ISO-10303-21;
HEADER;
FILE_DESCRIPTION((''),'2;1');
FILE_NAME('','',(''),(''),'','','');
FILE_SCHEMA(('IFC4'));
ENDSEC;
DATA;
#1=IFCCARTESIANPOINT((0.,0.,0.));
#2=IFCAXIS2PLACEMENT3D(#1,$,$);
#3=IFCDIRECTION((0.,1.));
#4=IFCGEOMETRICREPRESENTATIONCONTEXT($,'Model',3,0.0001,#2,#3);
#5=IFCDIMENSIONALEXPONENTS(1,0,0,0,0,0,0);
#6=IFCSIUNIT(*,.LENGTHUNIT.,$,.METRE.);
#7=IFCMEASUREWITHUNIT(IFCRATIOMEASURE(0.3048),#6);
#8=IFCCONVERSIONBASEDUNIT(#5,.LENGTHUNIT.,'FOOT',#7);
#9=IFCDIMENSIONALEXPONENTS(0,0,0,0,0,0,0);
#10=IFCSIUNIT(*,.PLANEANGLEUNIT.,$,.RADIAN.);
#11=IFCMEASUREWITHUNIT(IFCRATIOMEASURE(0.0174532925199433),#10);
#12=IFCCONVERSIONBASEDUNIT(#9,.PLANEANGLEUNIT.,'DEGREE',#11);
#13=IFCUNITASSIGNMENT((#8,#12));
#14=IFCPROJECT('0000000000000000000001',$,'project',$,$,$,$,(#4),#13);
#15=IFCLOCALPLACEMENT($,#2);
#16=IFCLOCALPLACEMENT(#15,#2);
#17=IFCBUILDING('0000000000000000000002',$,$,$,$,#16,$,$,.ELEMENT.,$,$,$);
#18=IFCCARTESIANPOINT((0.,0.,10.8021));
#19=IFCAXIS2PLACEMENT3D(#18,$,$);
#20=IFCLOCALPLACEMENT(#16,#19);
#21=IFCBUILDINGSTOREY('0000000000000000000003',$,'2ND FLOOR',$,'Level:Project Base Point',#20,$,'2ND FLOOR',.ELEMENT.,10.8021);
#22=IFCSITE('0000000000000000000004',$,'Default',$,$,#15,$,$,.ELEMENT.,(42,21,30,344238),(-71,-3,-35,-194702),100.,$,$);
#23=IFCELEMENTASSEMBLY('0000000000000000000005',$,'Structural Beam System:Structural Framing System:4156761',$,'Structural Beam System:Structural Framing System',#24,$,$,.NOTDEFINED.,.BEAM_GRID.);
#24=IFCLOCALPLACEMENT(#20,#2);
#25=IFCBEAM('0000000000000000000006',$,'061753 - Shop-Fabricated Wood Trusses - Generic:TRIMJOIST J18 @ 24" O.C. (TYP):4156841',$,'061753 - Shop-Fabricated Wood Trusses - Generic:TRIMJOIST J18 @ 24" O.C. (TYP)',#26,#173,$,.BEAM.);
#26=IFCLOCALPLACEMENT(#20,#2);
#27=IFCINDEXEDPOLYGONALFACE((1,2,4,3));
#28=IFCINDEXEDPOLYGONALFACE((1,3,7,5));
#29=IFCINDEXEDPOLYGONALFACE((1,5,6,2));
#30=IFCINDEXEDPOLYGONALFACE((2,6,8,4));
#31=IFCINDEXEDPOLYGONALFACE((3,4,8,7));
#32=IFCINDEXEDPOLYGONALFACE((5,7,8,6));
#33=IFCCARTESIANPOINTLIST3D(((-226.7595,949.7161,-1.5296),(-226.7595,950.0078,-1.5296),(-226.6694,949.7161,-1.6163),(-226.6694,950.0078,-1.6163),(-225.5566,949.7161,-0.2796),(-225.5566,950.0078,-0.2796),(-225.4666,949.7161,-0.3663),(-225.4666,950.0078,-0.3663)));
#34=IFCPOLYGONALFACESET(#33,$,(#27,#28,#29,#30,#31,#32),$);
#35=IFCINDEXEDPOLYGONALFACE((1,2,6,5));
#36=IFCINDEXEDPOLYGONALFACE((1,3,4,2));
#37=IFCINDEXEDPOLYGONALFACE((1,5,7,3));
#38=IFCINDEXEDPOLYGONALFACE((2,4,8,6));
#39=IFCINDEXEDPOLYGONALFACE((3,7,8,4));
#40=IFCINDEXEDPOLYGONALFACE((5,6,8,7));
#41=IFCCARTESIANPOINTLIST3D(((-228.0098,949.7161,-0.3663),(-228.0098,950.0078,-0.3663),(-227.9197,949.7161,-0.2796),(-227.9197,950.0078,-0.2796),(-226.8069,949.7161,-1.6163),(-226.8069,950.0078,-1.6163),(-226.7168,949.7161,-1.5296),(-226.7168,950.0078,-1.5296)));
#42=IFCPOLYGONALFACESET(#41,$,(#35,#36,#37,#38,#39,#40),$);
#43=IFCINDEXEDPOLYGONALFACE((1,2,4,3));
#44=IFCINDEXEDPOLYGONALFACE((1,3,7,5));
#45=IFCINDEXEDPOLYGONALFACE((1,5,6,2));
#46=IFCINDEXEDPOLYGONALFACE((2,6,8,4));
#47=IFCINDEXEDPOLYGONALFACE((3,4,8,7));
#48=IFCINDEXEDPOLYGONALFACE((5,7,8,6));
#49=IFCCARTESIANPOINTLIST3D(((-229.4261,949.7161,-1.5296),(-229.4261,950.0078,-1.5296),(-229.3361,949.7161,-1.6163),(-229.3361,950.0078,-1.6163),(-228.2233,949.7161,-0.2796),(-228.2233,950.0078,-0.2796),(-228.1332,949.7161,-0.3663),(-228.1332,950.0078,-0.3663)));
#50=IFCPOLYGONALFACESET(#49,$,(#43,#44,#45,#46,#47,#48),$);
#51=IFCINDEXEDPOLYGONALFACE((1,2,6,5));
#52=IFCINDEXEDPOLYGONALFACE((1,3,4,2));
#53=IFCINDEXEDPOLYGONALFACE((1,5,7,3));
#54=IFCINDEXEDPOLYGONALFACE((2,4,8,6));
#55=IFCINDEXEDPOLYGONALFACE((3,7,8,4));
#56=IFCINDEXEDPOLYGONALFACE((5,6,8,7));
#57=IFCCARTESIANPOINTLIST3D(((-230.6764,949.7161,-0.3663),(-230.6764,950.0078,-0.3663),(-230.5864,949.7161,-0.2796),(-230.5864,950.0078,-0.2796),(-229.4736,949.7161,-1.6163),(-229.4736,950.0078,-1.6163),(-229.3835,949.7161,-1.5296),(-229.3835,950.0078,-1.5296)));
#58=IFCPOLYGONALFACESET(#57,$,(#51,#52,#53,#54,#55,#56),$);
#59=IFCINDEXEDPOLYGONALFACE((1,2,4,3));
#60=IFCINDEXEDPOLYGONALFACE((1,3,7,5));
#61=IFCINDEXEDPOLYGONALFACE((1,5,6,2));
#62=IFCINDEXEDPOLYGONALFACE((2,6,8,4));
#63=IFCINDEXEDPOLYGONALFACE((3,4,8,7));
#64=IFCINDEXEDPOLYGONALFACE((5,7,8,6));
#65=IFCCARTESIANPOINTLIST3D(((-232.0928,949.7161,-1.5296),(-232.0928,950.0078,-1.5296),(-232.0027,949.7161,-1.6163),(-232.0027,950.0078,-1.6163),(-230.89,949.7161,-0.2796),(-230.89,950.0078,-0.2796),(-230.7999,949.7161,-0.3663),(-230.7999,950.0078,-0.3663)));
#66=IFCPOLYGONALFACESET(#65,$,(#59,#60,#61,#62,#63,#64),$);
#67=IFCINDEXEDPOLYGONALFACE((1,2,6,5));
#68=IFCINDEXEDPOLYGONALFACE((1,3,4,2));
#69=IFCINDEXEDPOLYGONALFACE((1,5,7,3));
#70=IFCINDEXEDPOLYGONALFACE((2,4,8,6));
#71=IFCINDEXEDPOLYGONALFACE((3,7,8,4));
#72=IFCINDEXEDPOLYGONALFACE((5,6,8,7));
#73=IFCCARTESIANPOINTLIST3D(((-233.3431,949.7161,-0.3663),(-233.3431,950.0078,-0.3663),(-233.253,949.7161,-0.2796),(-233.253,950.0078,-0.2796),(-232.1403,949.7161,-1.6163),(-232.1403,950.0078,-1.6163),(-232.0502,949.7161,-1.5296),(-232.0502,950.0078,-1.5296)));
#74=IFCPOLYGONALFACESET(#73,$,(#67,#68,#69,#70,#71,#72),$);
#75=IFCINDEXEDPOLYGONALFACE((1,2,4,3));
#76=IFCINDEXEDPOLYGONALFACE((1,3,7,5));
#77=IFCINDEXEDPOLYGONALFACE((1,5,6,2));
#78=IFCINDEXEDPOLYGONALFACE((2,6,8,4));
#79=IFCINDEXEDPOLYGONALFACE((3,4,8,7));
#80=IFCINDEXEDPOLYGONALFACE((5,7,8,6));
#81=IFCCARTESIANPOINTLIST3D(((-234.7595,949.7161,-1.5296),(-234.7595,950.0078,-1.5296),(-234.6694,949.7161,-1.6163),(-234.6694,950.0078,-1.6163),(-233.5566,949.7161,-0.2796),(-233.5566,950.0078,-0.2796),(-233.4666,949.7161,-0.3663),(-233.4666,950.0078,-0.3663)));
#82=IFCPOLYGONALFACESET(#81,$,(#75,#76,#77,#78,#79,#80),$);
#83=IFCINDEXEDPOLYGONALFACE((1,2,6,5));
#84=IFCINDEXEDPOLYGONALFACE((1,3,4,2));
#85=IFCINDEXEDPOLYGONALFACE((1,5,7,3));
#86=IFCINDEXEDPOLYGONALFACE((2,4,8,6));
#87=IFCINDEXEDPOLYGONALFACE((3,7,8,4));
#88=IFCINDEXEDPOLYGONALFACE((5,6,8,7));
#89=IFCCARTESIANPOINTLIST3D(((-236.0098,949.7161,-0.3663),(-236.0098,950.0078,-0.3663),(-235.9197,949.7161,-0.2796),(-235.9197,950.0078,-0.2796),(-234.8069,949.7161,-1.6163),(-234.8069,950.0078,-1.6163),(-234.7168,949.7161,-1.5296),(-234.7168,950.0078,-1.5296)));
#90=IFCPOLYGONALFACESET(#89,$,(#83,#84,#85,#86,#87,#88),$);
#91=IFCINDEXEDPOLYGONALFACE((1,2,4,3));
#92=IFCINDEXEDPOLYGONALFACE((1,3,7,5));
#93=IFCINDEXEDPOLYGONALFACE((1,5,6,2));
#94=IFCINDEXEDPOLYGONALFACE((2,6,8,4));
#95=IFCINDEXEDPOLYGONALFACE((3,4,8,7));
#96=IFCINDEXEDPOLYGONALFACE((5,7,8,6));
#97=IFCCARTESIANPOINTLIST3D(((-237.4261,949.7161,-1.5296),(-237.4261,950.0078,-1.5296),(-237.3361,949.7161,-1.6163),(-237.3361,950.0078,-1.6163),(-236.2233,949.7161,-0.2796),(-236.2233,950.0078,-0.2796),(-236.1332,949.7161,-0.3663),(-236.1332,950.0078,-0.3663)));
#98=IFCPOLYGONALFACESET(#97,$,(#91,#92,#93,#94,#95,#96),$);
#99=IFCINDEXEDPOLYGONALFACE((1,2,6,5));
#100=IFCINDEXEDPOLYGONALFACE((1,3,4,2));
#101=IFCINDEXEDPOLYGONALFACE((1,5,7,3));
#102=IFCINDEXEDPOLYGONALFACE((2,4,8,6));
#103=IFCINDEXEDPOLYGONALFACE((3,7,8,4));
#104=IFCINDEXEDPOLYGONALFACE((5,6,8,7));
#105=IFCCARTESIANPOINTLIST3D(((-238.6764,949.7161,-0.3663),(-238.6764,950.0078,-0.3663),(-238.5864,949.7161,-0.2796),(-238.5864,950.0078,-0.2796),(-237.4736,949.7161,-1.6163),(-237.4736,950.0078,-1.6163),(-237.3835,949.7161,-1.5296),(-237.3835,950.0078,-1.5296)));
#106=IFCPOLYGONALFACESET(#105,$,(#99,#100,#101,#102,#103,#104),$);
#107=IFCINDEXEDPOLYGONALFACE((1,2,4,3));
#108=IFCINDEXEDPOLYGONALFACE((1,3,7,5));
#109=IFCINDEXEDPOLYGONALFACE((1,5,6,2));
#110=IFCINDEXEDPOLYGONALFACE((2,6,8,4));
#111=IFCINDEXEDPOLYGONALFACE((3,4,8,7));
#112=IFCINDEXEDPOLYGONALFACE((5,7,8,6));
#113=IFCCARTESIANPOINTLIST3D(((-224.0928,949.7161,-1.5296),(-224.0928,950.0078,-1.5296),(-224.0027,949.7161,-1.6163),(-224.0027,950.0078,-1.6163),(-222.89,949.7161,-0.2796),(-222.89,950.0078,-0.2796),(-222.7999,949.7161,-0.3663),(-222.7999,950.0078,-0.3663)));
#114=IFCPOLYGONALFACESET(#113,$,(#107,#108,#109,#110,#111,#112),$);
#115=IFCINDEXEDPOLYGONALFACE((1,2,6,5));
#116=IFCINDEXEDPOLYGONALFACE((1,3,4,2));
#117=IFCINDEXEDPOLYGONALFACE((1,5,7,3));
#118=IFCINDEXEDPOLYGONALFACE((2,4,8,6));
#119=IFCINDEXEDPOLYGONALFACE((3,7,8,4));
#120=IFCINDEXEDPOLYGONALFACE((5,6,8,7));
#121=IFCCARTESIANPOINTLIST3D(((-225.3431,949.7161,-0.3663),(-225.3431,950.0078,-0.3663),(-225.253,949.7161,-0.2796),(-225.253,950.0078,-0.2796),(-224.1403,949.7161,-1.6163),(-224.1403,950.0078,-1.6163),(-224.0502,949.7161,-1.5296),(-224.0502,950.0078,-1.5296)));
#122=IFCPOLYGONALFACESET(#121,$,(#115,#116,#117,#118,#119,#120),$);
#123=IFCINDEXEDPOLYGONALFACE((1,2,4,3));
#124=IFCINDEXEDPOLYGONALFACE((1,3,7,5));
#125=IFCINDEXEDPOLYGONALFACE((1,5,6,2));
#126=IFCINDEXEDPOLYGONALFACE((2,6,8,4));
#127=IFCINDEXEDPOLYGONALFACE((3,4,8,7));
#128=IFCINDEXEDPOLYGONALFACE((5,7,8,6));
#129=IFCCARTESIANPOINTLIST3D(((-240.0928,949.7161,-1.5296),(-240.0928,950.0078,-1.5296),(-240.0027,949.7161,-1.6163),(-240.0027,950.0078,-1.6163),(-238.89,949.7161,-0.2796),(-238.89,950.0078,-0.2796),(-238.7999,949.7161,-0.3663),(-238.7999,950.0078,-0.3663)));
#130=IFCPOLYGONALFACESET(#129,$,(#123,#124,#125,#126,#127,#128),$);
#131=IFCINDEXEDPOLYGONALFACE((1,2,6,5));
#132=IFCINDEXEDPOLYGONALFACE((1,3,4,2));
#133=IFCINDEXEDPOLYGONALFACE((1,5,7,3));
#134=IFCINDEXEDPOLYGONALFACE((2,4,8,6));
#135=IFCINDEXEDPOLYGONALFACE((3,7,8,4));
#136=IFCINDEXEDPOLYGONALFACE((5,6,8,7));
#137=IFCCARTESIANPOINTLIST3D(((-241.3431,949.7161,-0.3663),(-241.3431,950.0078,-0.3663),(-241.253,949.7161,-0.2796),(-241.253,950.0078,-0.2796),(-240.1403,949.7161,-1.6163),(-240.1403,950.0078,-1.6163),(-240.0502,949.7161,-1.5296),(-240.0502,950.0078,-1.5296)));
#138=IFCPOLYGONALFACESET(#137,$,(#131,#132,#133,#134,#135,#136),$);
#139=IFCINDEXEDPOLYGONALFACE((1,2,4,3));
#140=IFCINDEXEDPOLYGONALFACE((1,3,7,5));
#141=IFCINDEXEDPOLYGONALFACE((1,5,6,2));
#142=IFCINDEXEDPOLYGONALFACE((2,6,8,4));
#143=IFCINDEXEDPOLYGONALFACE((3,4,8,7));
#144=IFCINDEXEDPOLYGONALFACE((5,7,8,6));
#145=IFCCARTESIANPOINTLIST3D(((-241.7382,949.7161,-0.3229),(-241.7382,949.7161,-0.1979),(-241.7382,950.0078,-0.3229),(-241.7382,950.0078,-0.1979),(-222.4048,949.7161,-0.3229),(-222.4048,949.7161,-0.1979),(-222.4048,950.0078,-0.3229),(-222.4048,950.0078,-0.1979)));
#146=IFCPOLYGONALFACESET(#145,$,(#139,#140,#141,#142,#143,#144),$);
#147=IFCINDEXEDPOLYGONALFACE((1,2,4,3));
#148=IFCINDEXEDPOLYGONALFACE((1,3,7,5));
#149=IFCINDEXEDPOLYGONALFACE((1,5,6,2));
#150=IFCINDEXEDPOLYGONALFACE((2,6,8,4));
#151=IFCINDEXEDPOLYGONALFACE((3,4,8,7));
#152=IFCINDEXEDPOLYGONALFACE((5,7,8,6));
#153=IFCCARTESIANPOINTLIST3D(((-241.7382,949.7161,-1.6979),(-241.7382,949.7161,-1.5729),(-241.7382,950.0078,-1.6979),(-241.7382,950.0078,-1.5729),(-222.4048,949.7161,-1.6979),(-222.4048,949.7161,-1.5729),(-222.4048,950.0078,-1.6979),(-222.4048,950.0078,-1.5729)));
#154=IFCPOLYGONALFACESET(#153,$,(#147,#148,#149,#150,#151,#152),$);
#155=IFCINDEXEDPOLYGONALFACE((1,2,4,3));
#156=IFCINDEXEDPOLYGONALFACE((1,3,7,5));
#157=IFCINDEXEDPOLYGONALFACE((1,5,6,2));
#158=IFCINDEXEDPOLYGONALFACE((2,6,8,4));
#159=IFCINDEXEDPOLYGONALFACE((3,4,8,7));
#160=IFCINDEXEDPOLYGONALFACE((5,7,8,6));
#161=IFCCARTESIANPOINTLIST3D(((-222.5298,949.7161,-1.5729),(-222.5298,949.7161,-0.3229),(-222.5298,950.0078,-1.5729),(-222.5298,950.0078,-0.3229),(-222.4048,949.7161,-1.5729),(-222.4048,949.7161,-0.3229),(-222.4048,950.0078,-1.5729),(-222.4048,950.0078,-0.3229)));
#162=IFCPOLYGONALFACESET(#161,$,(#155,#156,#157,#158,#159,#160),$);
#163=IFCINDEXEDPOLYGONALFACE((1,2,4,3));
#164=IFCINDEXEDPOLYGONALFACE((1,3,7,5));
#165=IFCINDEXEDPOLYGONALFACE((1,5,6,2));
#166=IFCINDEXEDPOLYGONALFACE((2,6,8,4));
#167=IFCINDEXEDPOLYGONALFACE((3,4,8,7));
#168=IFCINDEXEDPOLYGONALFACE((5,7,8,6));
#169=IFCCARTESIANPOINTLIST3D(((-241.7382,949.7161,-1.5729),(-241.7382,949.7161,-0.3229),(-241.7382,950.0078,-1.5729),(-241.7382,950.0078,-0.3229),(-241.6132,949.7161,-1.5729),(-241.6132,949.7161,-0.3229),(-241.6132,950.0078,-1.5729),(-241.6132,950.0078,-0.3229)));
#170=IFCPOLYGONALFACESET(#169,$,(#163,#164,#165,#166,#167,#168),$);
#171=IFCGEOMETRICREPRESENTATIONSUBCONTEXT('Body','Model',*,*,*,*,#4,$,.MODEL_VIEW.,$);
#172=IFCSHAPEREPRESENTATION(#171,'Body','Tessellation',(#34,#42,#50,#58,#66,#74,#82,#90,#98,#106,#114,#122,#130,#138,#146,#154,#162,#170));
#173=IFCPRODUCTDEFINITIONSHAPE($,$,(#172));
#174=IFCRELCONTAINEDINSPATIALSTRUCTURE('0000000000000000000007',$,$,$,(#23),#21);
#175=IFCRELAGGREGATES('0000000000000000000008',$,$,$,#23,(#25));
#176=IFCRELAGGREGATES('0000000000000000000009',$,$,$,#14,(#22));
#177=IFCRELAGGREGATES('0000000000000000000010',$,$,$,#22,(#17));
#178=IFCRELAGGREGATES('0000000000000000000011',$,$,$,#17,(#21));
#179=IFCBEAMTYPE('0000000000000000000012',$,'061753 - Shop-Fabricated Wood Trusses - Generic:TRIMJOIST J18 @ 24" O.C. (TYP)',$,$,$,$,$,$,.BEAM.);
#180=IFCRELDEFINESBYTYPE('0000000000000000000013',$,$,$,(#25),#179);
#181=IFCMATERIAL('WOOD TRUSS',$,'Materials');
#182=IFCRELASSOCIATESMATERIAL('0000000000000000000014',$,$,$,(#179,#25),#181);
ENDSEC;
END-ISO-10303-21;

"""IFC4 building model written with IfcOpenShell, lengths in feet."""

from ifc_helpers import new_model, entity, si_unit, converted_unit, direction, frame, frame_2d, origin, origin_2d_with_axis, place, context, subcontext, project, spatial, rectangle, extrude, source, transform, mapped, material, material_profile, profile_set, profile_usage, type_object, type_shapes, element, aggregate, save


model = new_model("IFC4")

# Units and contexts
model_context = context("Model", 3, precision=0.0001, world=origin(), true_north=direction((0.0, 1.0)))
body_context = subcontext(model_context, "Body", "Model", "MODEL_VIEW")
ifc_project = project(units=[converted_unit("LENGTHUNIT", "FOOT", entity("IfcRatioMeasure", 0.3048), si_unit("LENGTHUNIT", "METRE"), dimensions=[1, 0, 0, 0, 0, 0, 0]), converted_unit("PLANEANGLEUNIT", "DEGREE", entity("IfcRatioMeasure", 0.0174532925199433), si_unit("PLANEANGLEUNIT", "RADIAN"), dimensions=[0, 0, 0, 0, 0, 0, 0])], contexts=[model_context])

# Site, building, storey
site_placement = place(None, origin())
site = spatial("IfcSite", under=ifc_project, at=site_placement, Name="Default", CompositionType="ELEMENT", RefLatitude=(42, 21, 30, 344238), RefLongitude=(-71, -3, -35, -194702), RefElevation=100.0)
building_placement = place(site_placement, origin())
building = spatial("IfcBuilding", under=site, at=building_placement, CompositionType="ELEMENT")
storey_placement = place(building_placement, frame((0.0, 0.0, 10.8021)))
storey = spatial("IfcBuildingStorey", under=building, at=storey_placement, Name="2ND FLOOR", ObjectType="Level:Project Base Point", LongName="2ND FLOOR", CompositionType="ELEMENT", Elevation=10.8021)

# Element assembly, beam
assembly_1_placement = place(storey_placement, origin())
assembly_1 = element("IfcElementAssembly", 1, at=assembly_1_placement, inside=storey, Name="Structural Beam System:Structural Framing System:4156761", ObjectType="Structural Beam System:Structural Framing System", AssemblyPlace="NOTDEFINED", PredefinedType="BEAM_GRID")
ifc_material_1 = material(Name="WOOD TRUSS", Category="Materials")
ifc_material_profile_1 = material_profile(ifc_material_1, rectangle(XDim=1.7347, YDim=0.125, at=frame_2d((0.0, 0.0), x_axis=(1.0, 0.0))), Name="TRIMJOIST J18 @ 24\" O.C. (TYP)")
ifc_material_profile_2 = material_profile(ifc_material_1, rectangle(XDim=1.7347, YDim=0.125, at=frame_2d((0.0, 0.0), x_axis=(1.0, 0.0))), Name="TRIMJOIST J18 @ 24\" O.C. (TYP)")
ifc_material_profile_3 = material_profile(ifc_material_1, rectangle(XDim=1.7347, YDim=0.125, at=frame_2d((0.0, 0.0), x_axis=(1.0, 0.0))), Name="TRIMJOIST J18 @ 24\" O.C. (TYP)")
ifc_material_profile_4 = material_profile(ifc_material_1, rectangle(XDim=1.7347, YDim=0.125, at=frame_2d((0.0, 0.0), x_axis=(1.0, 0.0))), Name="TRIMJOIST J18 @ 24\" O.C. (TYP)")
ifc_material_profile_5 = material_profile(ifc_material_1, rectangle(XDim=1.7347, YDim=0.125, at=frame_2d((0.0, 0.0), x_axis=(1.0, 0.0))), Name="TRIMJOIST J18 @ 24\" O.C. (TYP)")
ifc_material_profile_6 = material_profile(ifc_material_1, rectangle(XDim=1.7347, YDim=0.125, at=frame_2d((0.0, 0.0), x_axis=(1.0, 0.0))), Name="TRIMJOIST J18 @ 24\" O.C. (TYP)")
ifc_material_profile_7 = material_profile(ifc_material_1, rectangle(XDim=1.7347, YDim=0.125, at=frame_2d((0.0, 0.0), x_axis=(1.0, 0.0))), Name="TRIMJOIST J18 @ 24\" O.C. (TYP)")
ifc_material_profile_8 = material_profile(ifc_material_1, rectangle(XDim=1.7347, YDim=0.125, at=frame_2d((0.0, 0.0), x_axis=(1.0, 0.0))), Name="TRIMJOIST J18 @ 24\" O.C. (TYP)")
ifc_material_profile_9 = material_profile(ifc_material_1, rectangle(XDim=1.7347, YDim=0.125, at=frame_2d((0.0, 0.0), x_axis=(1.0, 0.0))), Name="TRIMJOIST J18 @ 24\" O.C. (TYP)")
ifc_material_profile_10 = material_profile(ifc_material_1, rectangle(XDim=1.7347, YDim=0.125, at=origin_2d_with_axis()), Name="TRIMJOIST J18 @ 24\" O.C. (TYP)")
ifc_material_profile_11 = material_profile(ifc_material_1, rectangle(XDim=0.125, YDim=0.2917, at=origin_2d_with_axis()), Name="TRIMJOIST J18 @ 24\" O.C. (TYP)")
ifc_material_profile_12 = material_profile(ifc_material_1, rectangle(XDim=0.125, YDim=0.2917, at=origin_2d_with_axis()), Name="TRIMJOIST J18 @ 24\" O.C. (TYP)")
ifc_material_profile_13 = material_profile(ifc_material_1, rectangle(XDim=1.25, YDim=0.2917, at=origin_2d_with_axis()), Name="TRIMJOIST J18 @ 24\" O.C. (TYP)")
ifc_material_profile_14 = material_profile(ifc_material_1, rectangle(XDim=1.25, YDim=0.2917, at=origin_2d_with_axis()), Name="TRIMJOIST J18 @ 24\" O.C. (TYP)")
ifc_profile_set_1 = profile_set([ifc_material_profile_1, ifc_material_profile_2, ifc_material_profile_3, ifc_material_profile_4, ifc_material_profile_5, ifc_material_profile_6, ifc_material_profile_7, ifc_material_profile_8, ifc_material_profile_9, ifc_material_profile_10, ifc_material_profile_11, ifc_material_profile_12, ifc_material_profile_13, ifc_material_profile_14], Name="TRIMJOIST J18 @ 24\" O.C. (TYP)")
beam_type_1 = type_object("IfcBeamType", Name="061753 - Shop-Fabricated Wood Trusses - Generic:TRIMJOIST J18 @ 24\" O.C. (TYP)", PredefinedType="BEAM", material=ifc_profile_set_1)
shared_shape_1 = source(origin(), body_context, "Body", "SweptSolid", [
    extrude(rectangle(XDim=1.7347, YDim=0.125, at=frame_2d((0.0, 0.0), x_axis=(1.0, 0.0))), frame((5.9585, -0.1458, 0.0), z_axis=(0.0, 1.0, 0.0), x_axis=(0.693383, 0.0, 0.720569)), (0.0, 0.0, 1.0), 0.2917),
    extrude(rectangle(XDim=1.7347, YDim=0.125, at=origin_2d_with_axis()), frame((4.7082, -0.1458, 0.0), z_axis=(0.0, 1.0, 0.0), x_axis=(0.693383, 0.0, -0.720569)), (0.0, 0.0, 1.0), 0.2917),
    extrude(rectangle(XDim=1.7347, YDim=0.125, at=frame_2d((0.0, 0.0), x_axis=(1.0, 0.0))), frame((3.2918, -0.1458, 0.0), z_axis=(0.0, 1.0, 0.0), x_axis=(0.693383, 0.0, 0.720569)), (0.0, 0.0, 1.0), 0.2917),
    extrude(rectangle(XDim=1.7347, YDim=0.125, at=frame_2d((0.0, 0.0), x_axis=(1.0, 0.0))), frame((2.0415, -0.1458, 0.0), z_axis=(0.0, 1.0, 0.0), x_axis=(0.693383, 0.0, -0.720569)), (0.0, 0.0, 1.0), 0.2917),
    extrude(rectangle(XDim=1.7347, YDim=0.125, at=frame_2d((0.0, 0.0), x_axis=(1.0, 0.0))), frame((0.6251, -0.1458, 0.0), z_axis=(0.0, 1.0, 0.0), x_axis=(0.693383, 0.0, 0.720569)), (0.0, 0.0, 1.0), 0.2917),
    extrude(rectangle(XDim=1.7347, YDim=0.125, at=frame_2d((0.0, 0.0), x_axis=(1.0, 0.0))), frame((-0.6251, -0.1458, 0.0), z_axis=(0.0, 1.0, 0.0), x_axis=(0.693383, 0.0, -0.720569)), (0.0, 0.0, 1.0), 0.2917),
    extrude(rectangle(XDim=1.7347, YDim=0.125, at=frame_2d((0.0, 0.0), x_axis=(1.0, 0.0))), frame((-2.0415, -0.1458, 0.0), z_axis=(0.0, 1.0, 0.0), x_axis=(0.693383, 0.0, 0.720569)), (0.0, 0.0, 1.0), 0.2917),
    extrude(rectangle(XDim=1.7347, YDim=0.125, at=origin_2d_with_axis()), frame((-3.2918, -0.1458, 0.0), z_axis=(0.0, 1.0, 0.0), x_axis=(0.693383, 0.0, -0.720569)), (0.0, 0.0, 1.0), 0.2917),
    extrude(rectangle(XDim=1.7347, YDim=0.125, at=frame_2d((0.0, 0.0), x_axis=(1.0, 0.0))), frame((-4.7082, -0.1458, 0.0), z_axis=(0.0, 1.0, 0.0), x_axis=(0.693383, 0.0, 0.720569)), (0.0, 0.0, 1.0), 0.2917),
    extrude(rectangle(XDim=1.7347, YDim=0.125, at=frame_2d((0.0, 0.0), x_axis=(1.0, 0.0))), frame((-5.9585, -0.1458, 0.0), z_axis=(0.0, 1.0, 0.0), x_axis=(0.693383, 0.0, -0.720569)), (0.0, 0.0, 1.0), 0.2917),
    extrude(rectangle(XDim=1.7347, YDim=0.125, at=frame_2d((0.0, 0.0), x_axis=(1.0, 0.0))), frame((8.6251, -0.1458, 0.0), z_axis=(0.0, 1.0, 0.0), x_axis=(0.693383, 0.0, 0.720569)), (0.0, 0.0, 1.0), 0.2917),
    extrude(rectangle(XDim=1.7347, YDim=0.125, at=origin_2d_with_axis()), frame((7.3749, -0.1458, 0.0), z_axis=(0.0, 1.0, 0.0), x_axis=(0.693383, 0.0, -0.720569)), (0.0, 0.0, 1.0), 0.2917),
    extrude(rectangle(XDim=1.7347, YDim=0.125, at=frame_2d((0.0, 0.0), x_axis=(1.0, 0.0))), frame((-7.3749, -0.1458, 0.0), z_axis=(0.0, 1.0, 0.0), x_axis=(0.693383, 0.0, 0.720569)), (0.0, 0.0, 1.0), 0.2917),
    extrude(rectangle(XDim=1.7347, YDim=0.125, at=origin_2d_with_axis()), frame((-8.6251, -0.1458, 0.0), z_axis=(0.0, 1.0, 0.0), x_axis=(0.693383, 0.0, -0.720569)), (0.0, 0.0, 1.0), 0.2917),
    extrude(rectangle(XDim=0.125, YDim=0.2917, at=origin_2d_with_axis()), frame((-9.6667, 0.0, 0.6875), z_axis=(1.0, 0.0, 0.0), x_axis=(0.0, 0.0, -1.0)), (0.0, 0.0, 1.0), 19.3333),
    extrude(rectangle(XDim=0.125, YDim=0.2917, at=origin_2d_with_axis()), frame((-9.6667, 0.0, -0.6875), z_axis=(1.0, 0.0, 0.0), x_axis=(0.0, 0.0, -1.0)), (0.0, 0.0, 1.0), 19.3333),
    extrude(rectangle(XDim=1.25, YDim=0.2917, at=origin_2d_with_axis()), frame((9.5417, 0.0, 0.0), z_axis=(1.0, 0.0, 0.0), x_axis=(0.0, 0.0, -1.0)), (0.0, 0.0, 1.0), 0.125),
    extrude(rectangle(XDim=1.25, YDim=0.2917, at=origin_2d_with_axis()), frame((-9.6667, 0.0, 0.0), z_axis=(1.0, 0.0, 0.0), x_axis=(0.0, 0.0, -1.0)), (0.0, 0.0, 1.0), 0.125),
])
type_shapes(beam_type_1, [shared_shape_1])
ifc_profile_usage_1 = profile_usage(ifc_profile_set_1, cardinal=8)
beam_1_placement = place(assembly_1_placement, frame((-232.0715, 949.8619, -0.9479)))
beam_1 = element("IfcBeam", 2, at=beam_1_placement, type_object=beam_type_1, material=ifc_profile_usage_1, Name="061753 - Shop-Fabricated Wood Trusses - Generic:TRIMJOIST J18 @ 24\" O.C. (TYP):4156841", ObjectType="061753 - Shop-Fabricated Wood Trusses - Generic:TRIMJOIST J18 @ 24\" O.C. (TYP)", PredefinedType="BEAM", context=body_context, shape_type="MappedRepresentation", body=[
    mapped(shared_shape_1, transform((0.0, 0.0, 0.0), scale=1.0)),
])
aggregate(assembly_1, [beam_1])

save(model, "model.ifc")
